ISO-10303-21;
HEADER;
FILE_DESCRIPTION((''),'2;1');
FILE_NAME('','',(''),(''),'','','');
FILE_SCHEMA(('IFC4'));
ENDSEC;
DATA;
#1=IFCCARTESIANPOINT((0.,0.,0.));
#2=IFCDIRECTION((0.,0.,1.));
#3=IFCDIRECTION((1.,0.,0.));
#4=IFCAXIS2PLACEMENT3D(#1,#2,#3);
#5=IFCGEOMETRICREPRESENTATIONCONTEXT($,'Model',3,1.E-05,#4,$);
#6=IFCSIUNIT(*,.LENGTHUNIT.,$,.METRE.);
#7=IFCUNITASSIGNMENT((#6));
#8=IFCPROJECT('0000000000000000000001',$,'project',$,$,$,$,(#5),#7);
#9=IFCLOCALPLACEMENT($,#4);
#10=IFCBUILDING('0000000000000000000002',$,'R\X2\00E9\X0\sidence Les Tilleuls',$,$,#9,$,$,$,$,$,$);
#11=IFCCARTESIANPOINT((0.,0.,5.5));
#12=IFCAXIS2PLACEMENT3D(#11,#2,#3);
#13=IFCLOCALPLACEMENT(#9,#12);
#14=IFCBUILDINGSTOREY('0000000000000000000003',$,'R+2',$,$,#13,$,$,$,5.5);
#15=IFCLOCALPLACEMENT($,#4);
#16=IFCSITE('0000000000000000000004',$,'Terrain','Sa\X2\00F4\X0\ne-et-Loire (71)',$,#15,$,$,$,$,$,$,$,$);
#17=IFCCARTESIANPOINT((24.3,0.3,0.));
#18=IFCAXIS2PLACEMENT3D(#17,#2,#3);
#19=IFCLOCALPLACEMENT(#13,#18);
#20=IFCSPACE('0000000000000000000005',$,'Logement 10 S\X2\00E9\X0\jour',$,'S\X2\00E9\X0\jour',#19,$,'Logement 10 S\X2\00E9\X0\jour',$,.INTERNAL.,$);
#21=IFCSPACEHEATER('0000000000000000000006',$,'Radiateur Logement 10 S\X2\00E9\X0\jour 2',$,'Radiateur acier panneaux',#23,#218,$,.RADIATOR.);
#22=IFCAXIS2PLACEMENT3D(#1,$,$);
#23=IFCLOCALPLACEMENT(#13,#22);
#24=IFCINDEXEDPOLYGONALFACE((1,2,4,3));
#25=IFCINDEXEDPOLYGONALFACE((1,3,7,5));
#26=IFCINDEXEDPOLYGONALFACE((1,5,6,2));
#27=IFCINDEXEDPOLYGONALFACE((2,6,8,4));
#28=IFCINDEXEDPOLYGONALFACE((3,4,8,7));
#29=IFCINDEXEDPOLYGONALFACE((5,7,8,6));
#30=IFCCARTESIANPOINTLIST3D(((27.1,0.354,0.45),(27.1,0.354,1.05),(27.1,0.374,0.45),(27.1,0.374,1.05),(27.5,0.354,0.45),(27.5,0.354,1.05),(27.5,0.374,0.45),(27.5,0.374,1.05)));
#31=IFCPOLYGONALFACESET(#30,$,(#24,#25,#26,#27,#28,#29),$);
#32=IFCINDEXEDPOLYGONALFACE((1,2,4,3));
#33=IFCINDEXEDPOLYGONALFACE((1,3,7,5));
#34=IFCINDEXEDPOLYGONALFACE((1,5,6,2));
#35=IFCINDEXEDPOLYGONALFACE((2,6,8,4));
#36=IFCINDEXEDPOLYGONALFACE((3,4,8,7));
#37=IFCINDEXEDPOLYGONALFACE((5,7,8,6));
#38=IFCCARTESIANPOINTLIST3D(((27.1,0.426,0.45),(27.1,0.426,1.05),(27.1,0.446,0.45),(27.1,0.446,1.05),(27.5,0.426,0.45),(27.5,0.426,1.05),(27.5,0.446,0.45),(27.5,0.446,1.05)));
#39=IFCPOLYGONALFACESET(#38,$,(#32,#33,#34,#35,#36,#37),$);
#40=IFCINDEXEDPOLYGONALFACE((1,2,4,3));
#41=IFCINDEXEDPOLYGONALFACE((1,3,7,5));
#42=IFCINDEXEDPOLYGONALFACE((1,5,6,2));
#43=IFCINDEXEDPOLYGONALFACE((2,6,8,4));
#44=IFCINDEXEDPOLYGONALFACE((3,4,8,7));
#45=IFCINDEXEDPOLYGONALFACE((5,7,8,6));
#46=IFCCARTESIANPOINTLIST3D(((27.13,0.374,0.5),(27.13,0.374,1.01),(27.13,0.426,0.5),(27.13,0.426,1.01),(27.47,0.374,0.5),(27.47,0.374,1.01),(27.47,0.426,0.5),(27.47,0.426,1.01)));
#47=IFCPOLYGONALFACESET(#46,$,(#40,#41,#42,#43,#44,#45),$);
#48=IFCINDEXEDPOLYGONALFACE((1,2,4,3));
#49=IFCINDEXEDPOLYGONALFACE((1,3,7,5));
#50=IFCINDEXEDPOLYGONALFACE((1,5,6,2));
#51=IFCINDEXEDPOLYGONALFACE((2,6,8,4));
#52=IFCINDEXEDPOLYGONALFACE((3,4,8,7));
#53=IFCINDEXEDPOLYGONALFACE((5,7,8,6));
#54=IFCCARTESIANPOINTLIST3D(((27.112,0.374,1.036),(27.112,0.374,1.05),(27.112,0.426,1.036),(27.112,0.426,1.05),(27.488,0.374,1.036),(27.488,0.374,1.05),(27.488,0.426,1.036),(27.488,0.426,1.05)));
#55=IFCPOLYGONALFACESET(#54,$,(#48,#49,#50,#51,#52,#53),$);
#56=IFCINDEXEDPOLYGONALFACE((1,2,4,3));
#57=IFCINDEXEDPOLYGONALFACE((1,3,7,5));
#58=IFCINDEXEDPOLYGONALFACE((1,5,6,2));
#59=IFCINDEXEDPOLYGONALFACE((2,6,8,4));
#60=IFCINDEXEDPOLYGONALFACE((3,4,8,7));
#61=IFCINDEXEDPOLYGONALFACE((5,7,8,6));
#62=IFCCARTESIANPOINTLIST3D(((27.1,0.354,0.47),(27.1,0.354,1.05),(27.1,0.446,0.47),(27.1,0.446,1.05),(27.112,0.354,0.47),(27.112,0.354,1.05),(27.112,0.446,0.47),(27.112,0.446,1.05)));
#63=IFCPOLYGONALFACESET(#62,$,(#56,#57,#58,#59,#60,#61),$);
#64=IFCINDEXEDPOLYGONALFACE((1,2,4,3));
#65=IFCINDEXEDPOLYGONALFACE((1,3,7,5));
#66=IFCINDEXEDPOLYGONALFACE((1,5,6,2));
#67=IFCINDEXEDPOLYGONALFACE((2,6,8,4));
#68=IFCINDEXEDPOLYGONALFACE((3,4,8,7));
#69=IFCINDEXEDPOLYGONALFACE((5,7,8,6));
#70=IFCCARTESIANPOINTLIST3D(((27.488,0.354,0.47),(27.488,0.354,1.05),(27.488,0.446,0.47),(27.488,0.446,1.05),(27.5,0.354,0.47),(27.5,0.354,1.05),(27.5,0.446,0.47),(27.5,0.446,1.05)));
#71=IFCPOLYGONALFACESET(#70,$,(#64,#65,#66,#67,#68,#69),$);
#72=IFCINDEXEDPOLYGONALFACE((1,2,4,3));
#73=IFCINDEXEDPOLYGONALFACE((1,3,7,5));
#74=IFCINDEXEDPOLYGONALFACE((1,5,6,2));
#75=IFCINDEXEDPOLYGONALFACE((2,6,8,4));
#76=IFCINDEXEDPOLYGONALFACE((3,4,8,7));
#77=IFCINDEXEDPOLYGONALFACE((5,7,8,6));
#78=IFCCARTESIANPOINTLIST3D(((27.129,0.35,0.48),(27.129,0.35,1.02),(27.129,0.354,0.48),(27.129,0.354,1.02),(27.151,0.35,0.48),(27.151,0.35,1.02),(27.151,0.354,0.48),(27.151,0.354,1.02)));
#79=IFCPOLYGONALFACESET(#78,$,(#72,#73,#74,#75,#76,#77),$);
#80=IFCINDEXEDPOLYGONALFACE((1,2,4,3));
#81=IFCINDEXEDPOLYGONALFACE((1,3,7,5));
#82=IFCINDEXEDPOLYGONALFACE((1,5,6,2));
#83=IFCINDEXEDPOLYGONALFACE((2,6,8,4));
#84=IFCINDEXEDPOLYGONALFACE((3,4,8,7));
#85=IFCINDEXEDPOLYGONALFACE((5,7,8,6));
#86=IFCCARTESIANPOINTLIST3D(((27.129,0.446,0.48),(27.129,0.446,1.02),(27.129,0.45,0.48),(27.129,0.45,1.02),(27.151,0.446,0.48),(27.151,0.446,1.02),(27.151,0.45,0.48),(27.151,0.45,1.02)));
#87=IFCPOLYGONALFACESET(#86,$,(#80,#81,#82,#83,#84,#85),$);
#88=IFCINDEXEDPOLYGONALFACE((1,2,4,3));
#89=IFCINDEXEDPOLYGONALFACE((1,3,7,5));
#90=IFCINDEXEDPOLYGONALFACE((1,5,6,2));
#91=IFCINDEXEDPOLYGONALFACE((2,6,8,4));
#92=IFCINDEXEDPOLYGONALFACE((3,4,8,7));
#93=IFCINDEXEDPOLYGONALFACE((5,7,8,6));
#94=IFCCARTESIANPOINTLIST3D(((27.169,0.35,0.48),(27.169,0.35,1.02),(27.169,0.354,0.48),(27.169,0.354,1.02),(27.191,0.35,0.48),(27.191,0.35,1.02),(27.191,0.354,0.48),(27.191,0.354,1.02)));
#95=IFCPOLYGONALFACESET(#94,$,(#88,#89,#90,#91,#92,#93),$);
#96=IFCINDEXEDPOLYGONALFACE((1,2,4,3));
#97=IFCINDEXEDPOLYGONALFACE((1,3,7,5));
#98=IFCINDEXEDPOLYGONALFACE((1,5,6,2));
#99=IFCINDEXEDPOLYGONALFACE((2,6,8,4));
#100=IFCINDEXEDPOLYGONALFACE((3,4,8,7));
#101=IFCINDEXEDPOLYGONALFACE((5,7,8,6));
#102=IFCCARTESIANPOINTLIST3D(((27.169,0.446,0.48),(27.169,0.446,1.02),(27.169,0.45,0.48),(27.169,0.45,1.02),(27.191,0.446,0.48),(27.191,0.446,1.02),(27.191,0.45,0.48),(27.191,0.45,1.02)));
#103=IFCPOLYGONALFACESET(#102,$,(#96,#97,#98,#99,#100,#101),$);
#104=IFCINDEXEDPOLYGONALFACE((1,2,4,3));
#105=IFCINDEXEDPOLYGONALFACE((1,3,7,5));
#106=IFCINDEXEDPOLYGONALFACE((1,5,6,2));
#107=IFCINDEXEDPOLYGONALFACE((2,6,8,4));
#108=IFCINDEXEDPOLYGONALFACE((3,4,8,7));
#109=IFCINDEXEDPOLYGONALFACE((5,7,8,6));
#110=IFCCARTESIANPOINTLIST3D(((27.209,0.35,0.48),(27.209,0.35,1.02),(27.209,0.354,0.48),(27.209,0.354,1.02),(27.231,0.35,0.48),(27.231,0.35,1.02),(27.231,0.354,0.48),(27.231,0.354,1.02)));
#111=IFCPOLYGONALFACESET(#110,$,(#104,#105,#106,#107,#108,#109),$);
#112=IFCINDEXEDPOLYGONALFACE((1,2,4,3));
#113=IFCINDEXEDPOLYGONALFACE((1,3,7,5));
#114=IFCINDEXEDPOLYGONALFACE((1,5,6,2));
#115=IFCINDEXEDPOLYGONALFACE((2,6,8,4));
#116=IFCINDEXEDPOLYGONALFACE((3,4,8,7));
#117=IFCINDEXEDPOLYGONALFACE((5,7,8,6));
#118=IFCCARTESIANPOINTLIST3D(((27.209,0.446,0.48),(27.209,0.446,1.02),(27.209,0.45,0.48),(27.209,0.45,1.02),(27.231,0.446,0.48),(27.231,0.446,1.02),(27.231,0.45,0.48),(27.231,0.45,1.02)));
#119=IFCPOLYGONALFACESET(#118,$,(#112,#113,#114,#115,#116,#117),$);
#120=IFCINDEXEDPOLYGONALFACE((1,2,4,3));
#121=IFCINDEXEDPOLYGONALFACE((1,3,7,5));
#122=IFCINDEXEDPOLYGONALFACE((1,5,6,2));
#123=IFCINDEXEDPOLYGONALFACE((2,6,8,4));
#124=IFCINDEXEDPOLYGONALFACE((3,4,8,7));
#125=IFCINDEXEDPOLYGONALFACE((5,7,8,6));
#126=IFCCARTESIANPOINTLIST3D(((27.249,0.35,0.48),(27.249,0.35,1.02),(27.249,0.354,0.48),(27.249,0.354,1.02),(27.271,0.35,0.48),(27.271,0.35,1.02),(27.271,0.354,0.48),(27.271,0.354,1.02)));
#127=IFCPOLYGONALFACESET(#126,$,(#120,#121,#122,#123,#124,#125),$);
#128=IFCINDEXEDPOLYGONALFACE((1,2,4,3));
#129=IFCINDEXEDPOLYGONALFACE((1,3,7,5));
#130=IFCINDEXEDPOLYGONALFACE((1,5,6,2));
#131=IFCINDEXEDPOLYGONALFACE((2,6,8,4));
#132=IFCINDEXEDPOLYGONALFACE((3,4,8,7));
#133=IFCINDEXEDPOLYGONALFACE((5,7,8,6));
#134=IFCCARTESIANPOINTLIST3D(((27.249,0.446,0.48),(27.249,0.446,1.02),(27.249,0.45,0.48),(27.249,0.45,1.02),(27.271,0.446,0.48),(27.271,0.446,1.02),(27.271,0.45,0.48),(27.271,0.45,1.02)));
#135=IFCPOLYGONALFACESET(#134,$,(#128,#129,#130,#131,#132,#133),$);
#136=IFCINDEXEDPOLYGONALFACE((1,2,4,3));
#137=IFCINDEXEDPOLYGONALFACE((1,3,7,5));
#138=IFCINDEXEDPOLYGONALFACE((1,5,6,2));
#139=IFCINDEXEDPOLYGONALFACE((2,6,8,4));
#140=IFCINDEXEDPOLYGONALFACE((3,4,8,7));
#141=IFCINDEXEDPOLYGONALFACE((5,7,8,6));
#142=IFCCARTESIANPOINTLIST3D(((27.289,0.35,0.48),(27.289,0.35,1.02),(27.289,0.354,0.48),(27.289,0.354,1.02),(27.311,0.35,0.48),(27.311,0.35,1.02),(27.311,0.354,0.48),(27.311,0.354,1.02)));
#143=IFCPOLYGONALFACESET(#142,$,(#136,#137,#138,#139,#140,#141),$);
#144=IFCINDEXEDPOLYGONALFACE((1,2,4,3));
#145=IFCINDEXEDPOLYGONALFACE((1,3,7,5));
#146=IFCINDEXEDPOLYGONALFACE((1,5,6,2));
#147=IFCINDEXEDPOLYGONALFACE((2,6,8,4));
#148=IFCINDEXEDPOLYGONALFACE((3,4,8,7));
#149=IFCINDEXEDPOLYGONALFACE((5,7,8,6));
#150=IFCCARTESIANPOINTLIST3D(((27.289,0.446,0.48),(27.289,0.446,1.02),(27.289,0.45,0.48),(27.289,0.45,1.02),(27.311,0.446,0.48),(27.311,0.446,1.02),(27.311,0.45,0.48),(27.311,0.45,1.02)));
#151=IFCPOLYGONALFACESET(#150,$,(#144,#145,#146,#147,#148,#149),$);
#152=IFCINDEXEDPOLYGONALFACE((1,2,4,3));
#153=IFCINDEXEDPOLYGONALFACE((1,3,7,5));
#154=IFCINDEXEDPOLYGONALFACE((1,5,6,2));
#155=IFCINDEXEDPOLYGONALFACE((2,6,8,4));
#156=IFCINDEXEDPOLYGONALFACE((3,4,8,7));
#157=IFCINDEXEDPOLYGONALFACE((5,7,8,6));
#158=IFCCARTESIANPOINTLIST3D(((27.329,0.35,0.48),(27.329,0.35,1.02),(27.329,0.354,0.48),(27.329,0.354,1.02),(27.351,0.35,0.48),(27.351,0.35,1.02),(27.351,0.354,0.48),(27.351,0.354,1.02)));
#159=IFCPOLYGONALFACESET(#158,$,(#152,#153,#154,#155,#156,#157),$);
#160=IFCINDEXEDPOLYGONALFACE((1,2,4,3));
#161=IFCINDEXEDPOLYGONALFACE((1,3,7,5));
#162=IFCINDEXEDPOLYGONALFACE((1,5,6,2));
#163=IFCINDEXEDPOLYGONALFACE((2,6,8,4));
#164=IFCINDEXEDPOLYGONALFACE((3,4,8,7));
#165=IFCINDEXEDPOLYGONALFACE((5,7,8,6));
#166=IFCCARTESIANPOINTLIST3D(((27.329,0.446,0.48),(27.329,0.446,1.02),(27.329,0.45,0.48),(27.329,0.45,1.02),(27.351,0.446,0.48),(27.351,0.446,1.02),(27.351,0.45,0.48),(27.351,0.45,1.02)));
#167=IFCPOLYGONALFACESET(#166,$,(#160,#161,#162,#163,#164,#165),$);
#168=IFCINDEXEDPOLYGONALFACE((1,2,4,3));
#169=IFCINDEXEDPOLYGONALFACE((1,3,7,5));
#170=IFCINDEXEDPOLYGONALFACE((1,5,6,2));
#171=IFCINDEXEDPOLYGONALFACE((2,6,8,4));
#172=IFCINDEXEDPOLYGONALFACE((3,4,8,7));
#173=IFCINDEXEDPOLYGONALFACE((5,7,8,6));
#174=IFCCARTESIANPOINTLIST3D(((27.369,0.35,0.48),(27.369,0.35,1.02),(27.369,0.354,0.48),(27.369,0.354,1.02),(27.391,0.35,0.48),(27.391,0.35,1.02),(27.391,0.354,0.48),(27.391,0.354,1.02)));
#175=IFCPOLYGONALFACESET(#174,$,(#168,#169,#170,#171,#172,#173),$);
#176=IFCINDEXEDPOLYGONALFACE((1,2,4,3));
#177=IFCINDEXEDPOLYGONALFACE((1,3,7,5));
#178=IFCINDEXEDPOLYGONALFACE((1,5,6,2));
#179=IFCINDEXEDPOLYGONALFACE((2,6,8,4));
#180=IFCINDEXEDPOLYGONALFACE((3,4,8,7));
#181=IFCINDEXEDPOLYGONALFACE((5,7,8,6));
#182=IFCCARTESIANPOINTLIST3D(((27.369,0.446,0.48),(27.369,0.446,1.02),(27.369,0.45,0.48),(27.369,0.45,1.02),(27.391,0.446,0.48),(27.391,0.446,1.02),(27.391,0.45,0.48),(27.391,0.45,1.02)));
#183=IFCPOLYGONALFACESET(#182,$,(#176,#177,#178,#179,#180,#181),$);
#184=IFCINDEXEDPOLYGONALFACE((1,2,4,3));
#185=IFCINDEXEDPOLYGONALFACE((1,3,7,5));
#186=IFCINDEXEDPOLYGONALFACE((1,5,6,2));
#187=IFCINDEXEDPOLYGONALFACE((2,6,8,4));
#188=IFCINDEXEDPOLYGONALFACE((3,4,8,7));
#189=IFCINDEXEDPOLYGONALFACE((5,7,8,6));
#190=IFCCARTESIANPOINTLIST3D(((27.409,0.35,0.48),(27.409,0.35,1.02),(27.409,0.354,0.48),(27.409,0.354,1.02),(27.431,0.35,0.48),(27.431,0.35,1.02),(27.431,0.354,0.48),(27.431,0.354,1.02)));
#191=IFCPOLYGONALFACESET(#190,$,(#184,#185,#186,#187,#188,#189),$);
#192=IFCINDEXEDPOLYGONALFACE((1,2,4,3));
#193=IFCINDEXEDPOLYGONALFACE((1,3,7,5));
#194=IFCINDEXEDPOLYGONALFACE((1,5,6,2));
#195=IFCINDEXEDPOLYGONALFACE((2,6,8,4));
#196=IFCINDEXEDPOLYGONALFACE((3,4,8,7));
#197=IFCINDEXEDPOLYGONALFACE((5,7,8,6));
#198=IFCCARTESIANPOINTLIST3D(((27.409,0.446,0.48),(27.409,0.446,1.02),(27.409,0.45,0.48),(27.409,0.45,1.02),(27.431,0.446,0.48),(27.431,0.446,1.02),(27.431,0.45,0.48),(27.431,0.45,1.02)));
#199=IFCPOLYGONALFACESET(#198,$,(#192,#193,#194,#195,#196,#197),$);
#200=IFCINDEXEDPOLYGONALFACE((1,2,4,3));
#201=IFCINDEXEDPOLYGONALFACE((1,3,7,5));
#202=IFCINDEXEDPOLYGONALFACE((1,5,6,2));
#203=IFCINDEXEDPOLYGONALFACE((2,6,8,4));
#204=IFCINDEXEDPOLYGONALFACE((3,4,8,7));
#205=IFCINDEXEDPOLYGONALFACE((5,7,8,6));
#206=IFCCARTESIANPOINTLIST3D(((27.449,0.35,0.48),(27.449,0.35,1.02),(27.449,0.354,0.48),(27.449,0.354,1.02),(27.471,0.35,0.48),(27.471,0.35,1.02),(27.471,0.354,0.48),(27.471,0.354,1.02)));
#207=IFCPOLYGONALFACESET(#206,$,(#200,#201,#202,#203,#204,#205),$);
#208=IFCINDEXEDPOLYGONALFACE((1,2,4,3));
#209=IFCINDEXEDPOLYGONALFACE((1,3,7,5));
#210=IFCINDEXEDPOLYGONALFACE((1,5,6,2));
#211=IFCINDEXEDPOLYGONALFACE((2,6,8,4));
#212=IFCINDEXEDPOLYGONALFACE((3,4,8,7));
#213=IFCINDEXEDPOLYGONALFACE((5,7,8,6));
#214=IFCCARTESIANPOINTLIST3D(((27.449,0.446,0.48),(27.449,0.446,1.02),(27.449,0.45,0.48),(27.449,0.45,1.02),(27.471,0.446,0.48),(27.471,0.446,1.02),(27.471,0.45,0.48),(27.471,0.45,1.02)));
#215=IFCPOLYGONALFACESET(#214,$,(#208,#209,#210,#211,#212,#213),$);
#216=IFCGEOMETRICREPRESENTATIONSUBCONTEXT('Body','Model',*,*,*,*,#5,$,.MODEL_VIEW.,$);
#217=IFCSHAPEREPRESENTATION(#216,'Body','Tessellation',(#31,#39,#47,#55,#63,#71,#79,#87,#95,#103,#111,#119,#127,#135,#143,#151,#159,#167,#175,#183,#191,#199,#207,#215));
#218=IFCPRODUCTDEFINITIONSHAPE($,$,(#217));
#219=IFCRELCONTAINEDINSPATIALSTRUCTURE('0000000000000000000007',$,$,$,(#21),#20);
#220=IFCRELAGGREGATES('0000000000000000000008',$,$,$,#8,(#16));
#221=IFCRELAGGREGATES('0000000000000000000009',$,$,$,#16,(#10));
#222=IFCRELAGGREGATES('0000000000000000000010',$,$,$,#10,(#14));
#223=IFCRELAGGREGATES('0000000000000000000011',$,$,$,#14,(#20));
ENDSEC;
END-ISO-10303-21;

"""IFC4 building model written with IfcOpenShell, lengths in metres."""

from ifc_helpers import new_model, si_unit, frame, frame_2d, origin_with_axes, place, context, subcontext, project, spatial, rectangle, extrude, element, save


model = new_model("IFC4")

# Units and contexts
model_context = context("Model", 3, precision=1e-05, world=origin_with_axes())
body_context = subcontext(model_context, "Body", "Model", "MODEL_VIEW")
ifc_project = project(units=[si_unit("LENGTHUNIT", "METRE")], contexts=[model_context])

# Site, building, storey
site_placement = place(None, origin_with_axes())
site = spatial("IfcSite", under=ifc_project, at=site_placement, Name="Terrain", Description="Saône-et-Loire (71)")
building_placement = place(None, origin_with_axes())
building = spatial("IfcBuilding", under=site, at=building_placement, Name="Résidence Les Tilleuls")
storey_placement = place(building_placement, frame((0.0, 0.0, 5.5), z_axis=(0.0, 0.0, 1.0), x_axis=(1.0, 0.0, 0.0)))
storey = spatial("IfcBuildingStorey", under=building, at=storey_placement, Name="R+2", Elevation=5.5)

# Shared definitions
space_placement = place(storey_placement, frame((24.3, 0.3, 0.0), z_axis=(0.0, 0.0, 1.0), x_axis=(1.0, 0.0, 0.0)))
space = spatial("IfcSpace", under=storey, at=space_placement, Name="Logement 10 Séjour", ObjectType="Séjour", LongName="Logement 10 Séjour", PredefinedType="INTERNAL")

# Space heater
space_heater_1_placement = place(space_placement, frame((2.8, 0.05, 0.45), z_axis=(0.0, 0.0, 1.0), x_axis=(1.0, 0.0, 0.0)))
element("IfcSpaceHeater", 1, at=space_heater_1_placement, inside=space, Name="Radiateur Logement 10 Séjour 2", ObjectType="Radiateur acier panneaux", PredefinedType="RADIATOR", context=body_context, shape_type="SweptSolid", body=[
    extrude(rectangle(XDim=0.4, YDim=0.02, at=frame_2d((0.2, 0.01))), frame((0.0, 0.004, 0.0), z_axis=(0.0, 0.0, 1.0), x_axis=(1.0, 0.0, 0.0)), (0.0, 0.0, 1.0), 0.6),
    extrude(rectangle(XDim=0.4, YDim=0.02, at=frame_2d((0.2, 0.01))), frame((0.0, 0.076, 0.0), z_axis=(0.0, 0.0, 1.0), x_axis=(1.0, 0.0, 0.0)), (0.0, 0.0, 1.0), 0.6),
    extrude(rectangle(XDim=0.34, YDim=0.052, at=frame_2d((0.17, 0.026))), frame((0.03, 0.024, 0.05), z_axis=(0.0, 0.0, 1.0), x_axis=(1.0, 0.0, 0.0)), (0.0, 0.0, 1.0), 0.51),
    extrude(rectangle(XDim=0.376, YDim=0.052, at=frame_2d((0.188, 0.026))), frame((0.012, 0.024, 0.586), z_axis=(0.0, 0.0, 1.0), x_axis=(1.0, 0.0, 0.0)), (0.0, 0.0, 1.0), 0.014),
    extrude(rectangle(XDim=0.012, YDim=0.092, at=frame_2d((0.006, 0.046))), frame((0.0, 0.004, 0.02), z_axis=(0.0, 0.0, 1.0), x_axis=(1.0, 0.0, 0.0)), (0.0, 0.0, 1.0), 0.58),
    extrude(rectangle(XDim=0.012, YDim=0.092, at=frame_2d((0.006, 0.046))), frame((0.388, 0.004, 0.02), z_axis=(0.0, 0.0, 1.0), x_axis=(1.0, 0.0, 0.0)), (0.0, 0.0, 1.0), 0.58),
    extrude(rectangle(XDim=0.022, YDim=0.004, at=frame_2d((0.011, 0.002))), frame((0.029, 0.0, 0.03), z_axis=(0.0, 0.0, 1.0), x_axis=(1.0, 0.0, 0.0)), (0.0, 0.0, 1.0), 0.54),
    extrude(rectangle(XDim=0.022, YDim=0.004, at=frame_2d((0.011, 0.002))), frame((0.029, 0.096, 0.03), z_axis=(0.0, 0.0, 1.0), x_axis=(1.0, 0.0, 0.0)), (0.0, 0.0, 1.0), 0.54),
    extrude(rectangle(XDim=0.022, YDim=0.004, at=frame_2d((0.011, 0.002))), frame((0.069, 0.0, 0.03), z_axis=(0.0, 0.0, 1.0), x_axis=(1.0, 0.0, 0.0)), (0.0, 0.0, 1.0), 0.54),
    extrude(rectangle(XDim=0.022, YDim=0.004, at=frame_2d((0.011, 0.002))), frame((0.069, 0.096, 0.03), z_axis=(0.0, 0.0, 1.0), x_axis=(1.0, 0.0, 0.0)), (0.0, 0.0, 1.0), 0.54),
    extrude(rectangle(XDim=0.022, YDim=0.004, at=frame_2d((0.011, 0.002))), frame((0.109, 0.0, 0.03), z_axis=(0.0, 0.0, 1.0), x_axis=(1.0, 0.0, 0.0)), (0.0, 0.0, 1.0), 0.54),
    extrude(rectangle(XDim=0.022, YDim=0.004, at=frame_2d((0.011, 0.002))), frame((0.109, 0.096, 0.03), z_axis=(0.0, 0.0, 1.0), x_axis=(1.0, 0.0, 0.0)), (0.0, 0.0, 1.0), 0.54),
    extrude(rectangle(XDim=0.022, YDim=0.004, at=frame_2d((0.011, 0.002))), frame((0.149, 0.0, 0.03), z_axis=(0.0, 0.0, 1.0), x_axis=(1.0, 0.0, 0.0)), (0.0, 0.0, 1.0), 0.54),
    extrude(rectangle(XDim=0.022, YDim=0.004, at=frame_2d((0.011, 0.002))), frame((0.149, 0.096, 0.03), z_axis=(0.0, 0.0, 1.0), x_axis=(1.0, 0.0, 0.0)), (0.0, 0.0, 1.0), 0.54),
    extrude(rectangle(XDim=0.022, YDim=0.004, at=frame_2d((0.011, 0.002))), frame((0.189, 0.0, 0.03), z_axis=(0.0, 0.0, 1.0), x_axis=(1.0, 0.0, 0.0)), (0.0, 0.0, 1.0), 0.54),
    extrude(rectangle(XDim=0.022, YDim=0.004, at=frame_2d((0.011, 0.002))), frame((0.189, 0.096, 0.03), z_axis=(0.0, 0.0, 1.0), x_axis=(1.0, 0.0, 0.0)), (0.0, 0.0, 1.0), 0.54),
    extrude(rectangle(XDim=0.022, YDim=0.004, at=frame_2d((0.011, 0.002))), frame((0.229, 0.0, 0.03), z_axis=(0.0, 0.0, 1.0), x_axis=(1.0, 0.0, 0.0)), (0.0, 0.0, 1.0), 0.54),
    extrude(rectangle(XDim=0.022, YDim=0.004, at=frame_2d((0.011, 0.002))), frame((0.229, 0.096, 0.03), z_axis=(0.0, 0.0, 1.0), x_axis=(1.0, 0.0, 0.0)), (0.0, 0.0, 1.0), 0.54),
    extrude(rectangle(XDim=0.022, YDim=0.004, at=frame_2d((0.011, 0.002))), frame((0.269, 0.0, 0.03), z_axis=(0.0, 0.0, 1.0), x_axis=(1.0, 0.0, 0.0)), (0.0, 0.0, 1.0), 0.54),
    extrude(rectangle(XDim=0.022, YDim=0.004, at=frame_2d((0.011, 0.002))), frame((0.269, 0.096, 0.03), z_axis=(0.0, 0.0, 1.0), x_axis=(1.0, 0.0, 0.0)), (0.0, 0.0, 1.0), 0.54),
    extrude(rectangle(XDim=0.022, YDim=0.004, at=frame_2d((0.011, 0.002))), frame((0.309, 0.0, 0.03), z_axis=(0.0, 0.0, 1.0), x_axis=(1.0, 0.0, 0.0)), (0.0, 0.0, 1.0), 0.54),
    extrude(rectangle(XDim=0.022, YDim=0.004, at=frame_2d((0.011, 0.002))), frame((0.309, 0.096, 0.03), z_axis=(0.0, 0.0, 1.0), x_axis=(1.0, 0.0, 0.0)), (0.0, 0.0, 1.0), 0.54),
    extrude(rectangle(XDim=0.022, YDim=0.004, at=frame_2d((0.011, 0.002))), frame((0.349, 0.0, 0.03), z_axis=(0.0, 0.0, 1.0), x_axis=(1.0, 0.0, 0.0)), (0.0, 0.0, 1.0), 0.54),
    extrude(rectangle(XDim=0.022, YDim=0.004, at=frame_2d((0.011, 0.002))), frame((0.349, 0.096, 0.03), z_axis=(0.0, 0.0, 1.0), x_axis=(1.0, 0.0, 0.0)), (0.0, 0.0, 1.0), 0.54),
])

save(model, "model.ifc")
